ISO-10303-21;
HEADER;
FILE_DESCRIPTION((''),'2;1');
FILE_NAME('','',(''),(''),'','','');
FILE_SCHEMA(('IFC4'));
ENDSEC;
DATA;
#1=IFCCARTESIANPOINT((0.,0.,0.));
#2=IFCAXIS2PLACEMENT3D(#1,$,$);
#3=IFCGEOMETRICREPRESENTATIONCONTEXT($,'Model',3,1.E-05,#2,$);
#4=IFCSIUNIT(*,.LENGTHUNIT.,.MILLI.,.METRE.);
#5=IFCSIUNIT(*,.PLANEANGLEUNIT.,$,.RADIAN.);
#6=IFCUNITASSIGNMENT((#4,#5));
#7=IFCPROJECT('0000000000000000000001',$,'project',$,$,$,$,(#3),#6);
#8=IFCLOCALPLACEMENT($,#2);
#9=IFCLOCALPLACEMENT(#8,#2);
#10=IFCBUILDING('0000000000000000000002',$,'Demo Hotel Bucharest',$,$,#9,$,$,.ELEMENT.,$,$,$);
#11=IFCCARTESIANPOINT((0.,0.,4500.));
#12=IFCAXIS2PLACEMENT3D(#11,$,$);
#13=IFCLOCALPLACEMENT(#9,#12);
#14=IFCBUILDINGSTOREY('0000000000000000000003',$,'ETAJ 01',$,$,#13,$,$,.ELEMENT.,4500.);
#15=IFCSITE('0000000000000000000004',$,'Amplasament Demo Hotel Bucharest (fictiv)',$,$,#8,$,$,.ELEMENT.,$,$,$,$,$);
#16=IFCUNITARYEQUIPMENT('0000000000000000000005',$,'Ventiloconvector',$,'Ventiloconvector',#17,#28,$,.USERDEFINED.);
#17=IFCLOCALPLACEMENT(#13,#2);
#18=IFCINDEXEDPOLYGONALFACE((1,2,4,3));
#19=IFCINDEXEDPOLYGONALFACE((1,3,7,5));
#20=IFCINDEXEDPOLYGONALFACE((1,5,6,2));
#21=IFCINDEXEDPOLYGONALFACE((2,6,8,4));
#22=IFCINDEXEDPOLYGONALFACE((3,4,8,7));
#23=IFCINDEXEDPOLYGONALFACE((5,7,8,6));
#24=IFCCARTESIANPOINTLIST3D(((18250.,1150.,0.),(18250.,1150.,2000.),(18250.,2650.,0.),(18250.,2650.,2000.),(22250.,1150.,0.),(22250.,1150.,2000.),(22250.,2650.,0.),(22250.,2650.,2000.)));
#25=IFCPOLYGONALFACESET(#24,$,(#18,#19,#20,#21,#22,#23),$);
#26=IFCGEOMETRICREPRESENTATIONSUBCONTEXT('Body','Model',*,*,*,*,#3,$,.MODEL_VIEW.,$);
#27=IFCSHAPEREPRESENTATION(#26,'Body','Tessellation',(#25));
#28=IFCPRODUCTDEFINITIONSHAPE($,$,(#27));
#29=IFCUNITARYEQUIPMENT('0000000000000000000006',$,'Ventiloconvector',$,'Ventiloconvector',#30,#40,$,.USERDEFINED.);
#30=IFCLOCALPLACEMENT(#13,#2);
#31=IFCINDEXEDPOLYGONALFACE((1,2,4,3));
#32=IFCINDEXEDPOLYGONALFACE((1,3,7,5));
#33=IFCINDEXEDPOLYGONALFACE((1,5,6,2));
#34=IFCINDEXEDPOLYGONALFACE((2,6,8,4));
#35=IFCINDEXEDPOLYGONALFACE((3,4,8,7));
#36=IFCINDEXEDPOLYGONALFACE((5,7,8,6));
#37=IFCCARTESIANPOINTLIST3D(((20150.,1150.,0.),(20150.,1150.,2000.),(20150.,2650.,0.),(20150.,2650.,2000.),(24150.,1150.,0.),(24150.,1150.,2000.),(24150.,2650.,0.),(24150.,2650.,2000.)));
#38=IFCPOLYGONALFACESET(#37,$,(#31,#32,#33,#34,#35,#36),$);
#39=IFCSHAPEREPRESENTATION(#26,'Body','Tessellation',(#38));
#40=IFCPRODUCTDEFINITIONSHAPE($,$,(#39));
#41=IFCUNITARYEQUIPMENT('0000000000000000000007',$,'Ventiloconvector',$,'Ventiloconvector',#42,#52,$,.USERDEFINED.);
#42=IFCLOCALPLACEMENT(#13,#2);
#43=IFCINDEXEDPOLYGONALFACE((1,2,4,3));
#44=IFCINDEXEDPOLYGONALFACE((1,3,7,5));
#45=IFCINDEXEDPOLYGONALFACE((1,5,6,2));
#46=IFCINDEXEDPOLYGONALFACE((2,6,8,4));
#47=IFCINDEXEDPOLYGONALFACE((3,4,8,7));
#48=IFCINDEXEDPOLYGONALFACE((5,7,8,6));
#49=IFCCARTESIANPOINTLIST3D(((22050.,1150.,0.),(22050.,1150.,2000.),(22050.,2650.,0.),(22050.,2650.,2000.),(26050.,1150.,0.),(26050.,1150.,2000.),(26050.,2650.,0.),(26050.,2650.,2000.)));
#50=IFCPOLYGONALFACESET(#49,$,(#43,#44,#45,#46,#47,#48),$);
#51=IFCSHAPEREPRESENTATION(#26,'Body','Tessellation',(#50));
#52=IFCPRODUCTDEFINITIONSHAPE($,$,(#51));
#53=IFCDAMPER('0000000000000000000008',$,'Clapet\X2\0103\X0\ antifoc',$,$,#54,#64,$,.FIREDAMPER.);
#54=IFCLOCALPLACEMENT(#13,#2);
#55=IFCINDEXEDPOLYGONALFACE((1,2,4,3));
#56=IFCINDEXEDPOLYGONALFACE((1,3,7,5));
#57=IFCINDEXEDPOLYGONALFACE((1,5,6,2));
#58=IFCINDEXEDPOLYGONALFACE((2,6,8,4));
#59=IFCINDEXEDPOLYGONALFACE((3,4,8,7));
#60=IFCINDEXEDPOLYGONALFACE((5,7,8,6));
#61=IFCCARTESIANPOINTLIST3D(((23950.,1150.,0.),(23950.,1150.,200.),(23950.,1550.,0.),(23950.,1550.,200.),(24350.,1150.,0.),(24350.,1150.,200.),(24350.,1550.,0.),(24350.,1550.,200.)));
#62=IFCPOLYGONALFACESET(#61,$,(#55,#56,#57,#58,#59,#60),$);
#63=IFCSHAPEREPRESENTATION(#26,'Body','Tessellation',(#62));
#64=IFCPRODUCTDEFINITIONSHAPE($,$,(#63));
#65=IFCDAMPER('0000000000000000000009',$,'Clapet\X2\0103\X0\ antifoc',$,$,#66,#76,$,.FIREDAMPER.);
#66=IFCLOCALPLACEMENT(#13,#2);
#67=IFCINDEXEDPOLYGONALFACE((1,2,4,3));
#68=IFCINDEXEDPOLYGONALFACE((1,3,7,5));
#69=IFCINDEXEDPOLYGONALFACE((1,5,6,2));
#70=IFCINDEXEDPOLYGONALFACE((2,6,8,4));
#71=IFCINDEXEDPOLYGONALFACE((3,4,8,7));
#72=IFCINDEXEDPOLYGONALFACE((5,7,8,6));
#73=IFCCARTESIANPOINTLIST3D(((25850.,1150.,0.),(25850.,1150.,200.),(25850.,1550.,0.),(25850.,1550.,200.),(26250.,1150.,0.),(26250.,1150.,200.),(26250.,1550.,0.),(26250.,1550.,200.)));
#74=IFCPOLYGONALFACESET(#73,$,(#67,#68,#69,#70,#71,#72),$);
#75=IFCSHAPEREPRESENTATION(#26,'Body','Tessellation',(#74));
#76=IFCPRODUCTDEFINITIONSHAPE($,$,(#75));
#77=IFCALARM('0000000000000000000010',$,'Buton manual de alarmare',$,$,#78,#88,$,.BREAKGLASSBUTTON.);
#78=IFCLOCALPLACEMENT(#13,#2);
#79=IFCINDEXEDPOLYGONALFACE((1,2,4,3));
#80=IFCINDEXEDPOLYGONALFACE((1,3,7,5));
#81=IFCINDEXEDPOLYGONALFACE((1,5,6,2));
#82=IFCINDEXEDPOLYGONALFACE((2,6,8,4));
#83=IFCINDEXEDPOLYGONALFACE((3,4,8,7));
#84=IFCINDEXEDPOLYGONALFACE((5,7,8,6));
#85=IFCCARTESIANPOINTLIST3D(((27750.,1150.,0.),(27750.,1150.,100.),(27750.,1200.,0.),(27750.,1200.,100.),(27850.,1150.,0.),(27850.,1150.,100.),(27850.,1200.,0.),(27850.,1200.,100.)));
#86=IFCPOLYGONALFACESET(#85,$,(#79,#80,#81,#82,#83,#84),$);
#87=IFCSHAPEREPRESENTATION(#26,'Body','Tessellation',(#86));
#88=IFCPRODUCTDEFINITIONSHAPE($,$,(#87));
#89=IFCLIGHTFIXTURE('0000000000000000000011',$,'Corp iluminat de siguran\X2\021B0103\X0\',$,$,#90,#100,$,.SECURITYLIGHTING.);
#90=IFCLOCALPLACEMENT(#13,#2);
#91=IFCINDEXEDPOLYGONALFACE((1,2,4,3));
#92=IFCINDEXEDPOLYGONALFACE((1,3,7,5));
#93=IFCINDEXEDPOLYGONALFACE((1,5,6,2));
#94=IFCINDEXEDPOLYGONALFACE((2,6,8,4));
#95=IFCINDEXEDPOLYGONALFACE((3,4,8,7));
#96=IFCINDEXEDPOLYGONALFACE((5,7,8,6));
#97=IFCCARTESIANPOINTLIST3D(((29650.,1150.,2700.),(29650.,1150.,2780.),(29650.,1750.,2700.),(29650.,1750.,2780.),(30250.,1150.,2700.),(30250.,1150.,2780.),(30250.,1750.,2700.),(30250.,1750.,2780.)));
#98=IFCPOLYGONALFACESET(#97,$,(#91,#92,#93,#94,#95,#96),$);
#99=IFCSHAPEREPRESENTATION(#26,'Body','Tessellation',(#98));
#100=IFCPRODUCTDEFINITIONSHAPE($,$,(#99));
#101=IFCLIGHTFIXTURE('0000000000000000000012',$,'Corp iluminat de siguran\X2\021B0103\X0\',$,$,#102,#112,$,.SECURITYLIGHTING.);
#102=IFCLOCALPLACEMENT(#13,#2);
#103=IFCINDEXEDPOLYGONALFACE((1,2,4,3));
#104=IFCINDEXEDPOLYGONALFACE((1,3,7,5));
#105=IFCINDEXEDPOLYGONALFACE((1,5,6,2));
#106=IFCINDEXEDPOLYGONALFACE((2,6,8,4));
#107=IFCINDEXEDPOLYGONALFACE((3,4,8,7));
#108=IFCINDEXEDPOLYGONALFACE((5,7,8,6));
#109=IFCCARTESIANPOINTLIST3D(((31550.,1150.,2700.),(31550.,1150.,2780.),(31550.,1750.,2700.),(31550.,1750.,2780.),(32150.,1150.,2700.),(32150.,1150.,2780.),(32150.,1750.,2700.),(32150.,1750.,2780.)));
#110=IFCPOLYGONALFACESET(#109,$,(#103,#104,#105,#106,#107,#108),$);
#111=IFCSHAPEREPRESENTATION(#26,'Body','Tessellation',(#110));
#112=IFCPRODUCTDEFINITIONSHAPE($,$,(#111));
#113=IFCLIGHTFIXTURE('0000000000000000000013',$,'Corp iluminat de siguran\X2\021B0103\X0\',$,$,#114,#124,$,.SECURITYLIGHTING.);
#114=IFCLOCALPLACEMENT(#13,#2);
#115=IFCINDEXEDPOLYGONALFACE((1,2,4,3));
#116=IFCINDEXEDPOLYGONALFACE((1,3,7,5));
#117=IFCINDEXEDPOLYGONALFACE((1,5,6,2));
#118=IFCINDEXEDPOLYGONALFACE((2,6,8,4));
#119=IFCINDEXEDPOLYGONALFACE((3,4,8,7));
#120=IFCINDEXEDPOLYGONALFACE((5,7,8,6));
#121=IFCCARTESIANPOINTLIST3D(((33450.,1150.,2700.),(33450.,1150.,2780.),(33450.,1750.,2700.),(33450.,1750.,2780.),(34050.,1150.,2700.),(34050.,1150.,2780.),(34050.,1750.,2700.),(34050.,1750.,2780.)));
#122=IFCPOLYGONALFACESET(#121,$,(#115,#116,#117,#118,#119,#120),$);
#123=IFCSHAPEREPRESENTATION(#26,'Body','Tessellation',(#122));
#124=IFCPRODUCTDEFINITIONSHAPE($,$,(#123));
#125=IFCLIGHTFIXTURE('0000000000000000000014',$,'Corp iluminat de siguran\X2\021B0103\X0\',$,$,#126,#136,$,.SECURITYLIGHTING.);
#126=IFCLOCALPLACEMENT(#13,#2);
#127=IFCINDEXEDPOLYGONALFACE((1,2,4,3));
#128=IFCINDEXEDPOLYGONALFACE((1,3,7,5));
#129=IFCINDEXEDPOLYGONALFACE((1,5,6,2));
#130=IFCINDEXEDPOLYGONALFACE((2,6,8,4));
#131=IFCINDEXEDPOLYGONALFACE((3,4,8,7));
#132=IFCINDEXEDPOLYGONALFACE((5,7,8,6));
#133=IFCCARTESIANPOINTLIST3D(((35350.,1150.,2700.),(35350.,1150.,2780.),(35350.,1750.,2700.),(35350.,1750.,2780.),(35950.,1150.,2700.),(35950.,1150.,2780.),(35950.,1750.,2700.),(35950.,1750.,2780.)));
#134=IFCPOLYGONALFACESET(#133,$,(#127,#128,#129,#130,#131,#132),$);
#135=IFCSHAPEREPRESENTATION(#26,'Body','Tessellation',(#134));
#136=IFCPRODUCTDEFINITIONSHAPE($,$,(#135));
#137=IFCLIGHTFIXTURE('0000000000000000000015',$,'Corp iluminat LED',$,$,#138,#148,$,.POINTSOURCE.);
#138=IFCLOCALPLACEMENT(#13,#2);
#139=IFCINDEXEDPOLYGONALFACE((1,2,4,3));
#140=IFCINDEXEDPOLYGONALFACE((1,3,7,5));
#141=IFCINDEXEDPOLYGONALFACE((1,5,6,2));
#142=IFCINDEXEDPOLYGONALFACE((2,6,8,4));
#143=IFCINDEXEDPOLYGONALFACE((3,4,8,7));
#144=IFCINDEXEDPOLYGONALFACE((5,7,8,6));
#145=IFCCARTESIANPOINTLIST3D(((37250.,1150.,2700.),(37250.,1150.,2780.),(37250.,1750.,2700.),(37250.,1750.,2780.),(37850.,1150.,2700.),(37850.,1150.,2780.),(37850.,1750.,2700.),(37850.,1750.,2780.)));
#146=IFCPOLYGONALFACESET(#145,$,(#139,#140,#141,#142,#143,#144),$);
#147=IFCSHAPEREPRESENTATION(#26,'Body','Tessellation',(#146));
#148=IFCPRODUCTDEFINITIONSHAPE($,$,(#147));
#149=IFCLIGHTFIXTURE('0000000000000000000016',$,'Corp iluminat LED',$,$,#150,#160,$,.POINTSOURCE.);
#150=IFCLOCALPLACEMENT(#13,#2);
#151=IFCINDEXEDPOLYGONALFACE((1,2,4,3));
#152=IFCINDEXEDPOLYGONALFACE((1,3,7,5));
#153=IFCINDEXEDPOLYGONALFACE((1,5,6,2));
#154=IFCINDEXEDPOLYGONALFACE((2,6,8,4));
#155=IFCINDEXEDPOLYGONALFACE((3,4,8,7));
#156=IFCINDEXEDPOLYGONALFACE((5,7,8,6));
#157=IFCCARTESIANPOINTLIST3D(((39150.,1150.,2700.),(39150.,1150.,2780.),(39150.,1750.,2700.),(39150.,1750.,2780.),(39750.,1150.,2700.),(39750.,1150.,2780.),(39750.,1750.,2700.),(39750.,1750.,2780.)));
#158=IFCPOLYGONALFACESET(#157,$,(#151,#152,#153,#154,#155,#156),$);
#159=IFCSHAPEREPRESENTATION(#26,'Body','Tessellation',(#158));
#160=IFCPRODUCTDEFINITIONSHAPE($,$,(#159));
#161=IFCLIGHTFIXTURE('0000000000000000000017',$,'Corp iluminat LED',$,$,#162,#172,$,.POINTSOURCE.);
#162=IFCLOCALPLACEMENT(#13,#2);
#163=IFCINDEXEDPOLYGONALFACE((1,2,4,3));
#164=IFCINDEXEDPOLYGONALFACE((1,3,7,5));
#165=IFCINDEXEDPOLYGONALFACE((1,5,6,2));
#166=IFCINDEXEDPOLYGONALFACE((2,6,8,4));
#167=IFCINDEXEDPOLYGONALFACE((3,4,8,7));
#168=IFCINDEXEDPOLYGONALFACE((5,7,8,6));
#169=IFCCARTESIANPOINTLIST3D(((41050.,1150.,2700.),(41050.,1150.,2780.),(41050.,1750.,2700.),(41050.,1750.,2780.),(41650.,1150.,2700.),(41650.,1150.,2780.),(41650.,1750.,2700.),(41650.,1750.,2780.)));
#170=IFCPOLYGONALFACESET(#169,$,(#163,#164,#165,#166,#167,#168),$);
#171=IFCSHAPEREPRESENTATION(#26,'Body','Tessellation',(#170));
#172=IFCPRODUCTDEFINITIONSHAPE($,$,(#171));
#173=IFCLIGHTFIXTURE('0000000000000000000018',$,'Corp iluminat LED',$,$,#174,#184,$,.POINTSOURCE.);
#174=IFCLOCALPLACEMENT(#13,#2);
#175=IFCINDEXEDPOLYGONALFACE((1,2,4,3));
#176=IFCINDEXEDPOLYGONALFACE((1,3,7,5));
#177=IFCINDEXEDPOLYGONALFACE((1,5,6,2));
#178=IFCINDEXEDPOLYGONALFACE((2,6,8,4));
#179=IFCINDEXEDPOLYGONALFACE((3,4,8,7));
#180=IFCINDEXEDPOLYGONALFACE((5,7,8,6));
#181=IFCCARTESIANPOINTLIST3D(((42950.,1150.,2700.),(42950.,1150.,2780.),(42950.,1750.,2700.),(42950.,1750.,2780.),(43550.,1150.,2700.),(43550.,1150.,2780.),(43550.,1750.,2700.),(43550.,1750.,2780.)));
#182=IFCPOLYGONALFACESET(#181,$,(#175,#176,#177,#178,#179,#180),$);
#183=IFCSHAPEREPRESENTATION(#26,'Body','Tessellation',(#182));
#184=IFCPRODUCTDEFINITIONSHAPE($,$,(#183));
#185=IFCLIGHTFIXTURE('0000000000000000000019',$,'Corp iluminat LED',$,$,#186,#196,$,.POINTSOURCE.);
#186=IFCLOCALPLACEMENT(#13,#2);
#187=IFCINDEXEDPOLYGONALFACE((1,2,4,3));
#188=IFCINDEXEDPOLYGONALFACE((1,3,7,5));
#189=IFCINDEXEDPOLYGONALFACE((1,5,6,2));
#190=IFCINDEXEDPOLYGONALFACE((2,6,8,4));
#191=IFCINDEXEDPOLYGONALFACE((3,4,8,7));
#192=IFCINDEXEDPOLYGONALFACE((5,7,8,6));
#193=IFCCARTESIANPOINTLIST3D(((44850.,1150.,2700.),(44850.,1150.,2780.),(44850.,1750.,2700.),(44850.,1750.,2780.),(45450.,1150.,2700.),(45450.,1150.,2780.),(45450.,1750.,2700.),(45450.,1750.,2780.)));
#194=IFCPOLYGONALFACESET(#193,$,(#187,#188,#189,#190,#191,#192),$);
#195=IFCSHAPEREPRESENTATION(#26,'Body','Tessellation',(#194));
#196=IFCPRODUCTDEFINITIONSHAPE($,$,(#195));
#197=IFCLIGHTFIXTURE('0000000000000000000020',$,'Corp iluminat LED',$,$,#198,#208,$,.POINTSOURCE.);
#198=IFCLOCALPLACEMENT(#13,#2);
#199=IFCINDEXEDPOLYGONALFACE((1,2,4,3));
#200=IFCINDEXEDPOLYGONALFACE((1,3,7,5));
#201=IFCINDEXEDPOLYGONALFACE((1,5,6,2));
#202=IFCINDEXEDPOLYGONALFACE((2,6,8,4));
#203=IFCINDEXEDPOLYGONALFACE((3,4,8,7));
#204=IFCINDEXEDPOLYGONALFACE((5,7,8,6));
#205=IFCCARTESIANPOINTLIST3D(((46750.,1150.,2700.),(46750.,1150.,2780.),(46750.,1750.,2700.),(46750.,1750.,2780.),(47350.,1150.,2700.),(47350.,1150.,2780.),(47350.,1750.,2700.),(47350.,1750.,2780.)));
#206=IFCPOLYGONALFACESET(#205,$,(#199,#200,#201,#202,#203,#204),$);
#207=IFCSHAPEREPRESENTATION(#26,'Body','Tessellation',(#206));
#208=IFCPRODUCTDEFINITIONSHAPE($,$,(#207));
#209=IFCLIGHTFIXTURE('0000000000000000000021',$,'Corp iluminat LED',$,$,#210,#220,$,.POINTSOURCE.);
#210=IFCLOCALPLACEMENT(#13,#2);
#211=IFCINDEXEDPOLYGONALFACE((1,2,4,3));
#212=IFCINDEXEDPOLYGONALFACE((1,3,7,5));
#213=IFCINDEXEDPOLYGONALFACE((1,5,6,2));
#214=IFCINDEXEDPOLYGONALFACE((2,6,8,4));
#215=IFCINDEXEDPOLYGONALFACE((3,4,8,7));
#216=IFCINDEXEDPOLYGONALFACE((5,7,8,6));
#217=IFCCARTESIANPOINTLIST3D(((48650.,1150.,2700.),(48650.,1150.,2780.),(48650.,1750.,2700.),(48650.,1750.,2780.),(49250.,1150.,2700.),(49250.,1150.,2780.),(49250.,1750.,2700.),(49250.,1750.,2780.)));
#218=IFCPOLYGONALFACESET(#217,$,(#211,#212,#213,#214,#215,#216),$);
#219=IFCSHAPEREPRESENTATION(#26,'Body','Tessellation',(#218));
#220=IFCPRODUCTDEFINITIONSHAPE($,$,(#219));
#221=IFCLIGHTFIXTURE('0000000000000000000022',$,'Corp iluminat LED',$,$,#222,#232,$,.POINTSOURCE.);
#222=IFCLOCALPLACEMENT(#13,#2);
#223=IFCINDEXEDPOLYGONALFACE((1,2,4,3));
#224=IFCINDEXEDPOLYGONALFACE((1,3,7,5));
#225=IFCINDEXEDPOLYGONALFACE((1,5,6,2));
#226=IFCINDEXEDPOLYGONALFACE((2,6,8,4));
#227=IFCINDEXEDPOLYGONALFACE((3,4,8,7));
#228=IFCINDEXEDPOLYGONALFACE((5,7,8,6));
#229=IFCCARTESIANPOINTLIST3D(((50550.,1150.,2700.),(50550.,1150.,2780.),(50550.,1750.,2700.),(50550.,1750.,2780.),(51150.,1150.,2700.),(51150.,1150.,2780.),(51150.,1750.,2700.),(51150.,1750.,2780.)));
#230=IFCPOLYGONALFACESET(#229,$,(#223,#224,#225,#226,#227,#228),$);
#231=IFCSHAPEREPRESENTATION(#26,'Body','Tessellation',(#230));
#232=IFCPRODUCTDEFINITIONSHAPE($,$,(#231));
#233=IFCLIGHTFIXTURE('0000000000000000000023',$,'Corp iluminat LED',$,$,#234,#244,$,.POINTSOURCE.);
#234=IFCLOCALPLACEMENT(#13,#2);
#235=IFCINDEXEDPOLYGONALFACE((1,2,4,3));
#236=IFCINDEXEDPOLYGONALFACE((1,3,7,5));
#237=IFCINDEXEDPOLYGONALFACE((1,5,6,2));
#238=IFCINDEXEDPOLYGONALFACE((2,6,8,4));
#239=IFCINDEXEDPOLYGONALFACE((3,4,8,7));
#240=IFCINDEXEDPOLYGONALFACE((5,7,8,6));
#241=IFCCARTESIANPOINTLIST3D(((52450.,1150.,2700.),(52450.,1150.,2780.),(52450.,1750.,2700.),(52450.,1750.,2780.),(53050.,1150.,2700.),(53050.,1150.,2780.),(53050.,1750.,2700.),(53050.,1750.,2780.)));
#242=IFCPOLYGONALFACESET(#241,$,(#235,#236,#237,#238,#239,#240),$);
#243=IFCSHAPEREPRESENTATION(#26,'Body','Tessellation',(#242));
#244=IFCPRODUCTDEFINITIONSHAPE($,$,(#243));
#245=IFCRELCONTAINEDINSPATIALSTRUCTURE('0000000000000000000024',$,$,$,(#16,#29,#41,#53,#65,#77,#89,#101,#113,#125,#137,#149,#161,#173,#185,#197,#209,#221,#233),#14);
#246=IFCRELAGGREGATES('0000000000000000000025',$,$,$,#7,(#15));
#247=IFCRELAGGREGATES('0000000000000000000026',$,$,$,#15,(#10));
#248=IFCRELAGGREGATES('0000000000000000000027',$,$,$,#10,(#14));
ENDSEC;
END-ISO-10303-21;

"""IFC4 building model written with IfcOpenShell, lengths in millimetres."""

from ifc_helpers import new_model, si_unit, frame, frame_2d, origin, place, context, subcontext, project, spatial, rectangle, extrude, element, save


model = new_model("IFC4")

# Units and contexts
model_context = context("Model", 3, precision=1e-05, world=origin())
body_context = subcontext(model_context, "Body", "Model", "MODEL_VIEW")
ifc_project = project(units=[si_unit("LENGTHUNIT", "METRE", prefix="MILLI"), si_unit("PLANEANGLEUNIT", "RADIAN")], contexts=[model_context])

# Site, building, storey
site_placement = place(None, origin())
site = spatial("IfcSite", under=ifc_project, at=site_placement, Name="Amplasament Demo Hotel Bucharest (fictiv)", CompositionType="ELEMENT")
building_placement = place(site_placement, origin())
building = spatial("IfcBuilding", under=site, at=building_placement, Name="Demo Hotel Bucharest", CompositionType="ELEMENT")
storey_placement = place(building_placement, frame((0.0, 0.0, 4500.0)))
storey = spatial("IfcBuildingStorey", under=building, at=storey_placement, Name="ETAJ 01", CompositionType="ELEMENT", Elevation=4500.0)

# Unitary equipment
for number, where, name in (
    (1, (18250.0, 1150.0, 0.0), "Ventiloconvector"),
    (2, (20150.0, 1150.0, 0.0), "Ventiloconvector"),
    (3, (22050.0, 1150.0, 0.0), "Ventiloconvector"),
):
    element("IfcUnitaryEquipment", number, at=place(storey_placement, frame(where)), inside=storey, Name=name, ObjectType="Ventiloconvector", PredefinedType="USERDEFINED", context=body_context, shape_type="SweptSolid", body=[
        extrude(rectangle(XDim=4000.0, YDim=1500.0, at=frame_2d((2000.0, 750.0))), origin(), (0.0, 0.0, 1.0), 2000.0),
    ])

# Dampers
for number, where, name in (
    (4, (23950.0, 1150.0, 0.0), "Clapetă antifoc"),
    (5, (25850.0, 1150.0, 0.0), "Clapetă antifoc"),
):
    element("IfcDamper", number, at=place(storey_placement, frame(where)), inside=storey, Name=name, PredefinedType="FIREDAMPER", context=body_context, shape_type="SweptSolid", body=[
        extrude(rectangle(XDim=400.0, YDim=400.0, at=frame_2d((200.0, 200.0))), origin(), (0.0, 0.0, 1.0), 200.0),
    ])

# Alarm
alarm_placement = place(storey_placement, frame((27750.0, 1150.0, 0.0)))
element("IfcAlarm", 6, at=alarm_placement, inside=storey, Name="Buton manual de alarmare", PredefinedType="BREAKGLASSBUTTON", context=body_context, shape_type="SweptSolid", body=[
    extrude(rectangle(XDim=100.0, YDim=50.0, at=frame_2d((50.0, 25.0))), origin(), (0.0, 0.0, 1.0), 100.0),
])

# Light fixtures
for number, where, name in (
    (7, (29650.0, 1150.0, 2700.0), "Corp iluminat de siguranță"),
    (8, (31550.0, 1150.0, 2700.0), "Corp iluminat de siguranță"),
    (9, (33450.0, 1150.0, 2700.0), "Corp iluminat de siguranță"),
    (10, (35350.0, 1150.0, 2700.0), "Corp iluminat de siguranță"),
):
    element("IfcLightFixture", number, at=place(storey_placement, frame(where)), inside=storey, Name=name, PredefinedType="SECURITYLIGHTING", context=body_context, shape_type="SweptSolid", body=[
        extrude(rectangle(XDim=600.0, YDim=600.0, at=frame_2d((300.0, 300.0))), origin(), (0.0, 0.0, 1.0), 80.0),
    ])
for number, where, name in (
    (11, (37250.0, 1150.0, 2700.0), "Corp iluminat LED"),
    (12, (39150.0, 1150.0, 2700.0), "Corp iluminat LED"),
    (13, (41050.0, 1150.0, 2700.0), "Corp iluminat LED"),
    (14, (42950.0, 1150.0, 2700.0), "Corp iluminat LED"),
    (15, (44850.0, 1150.0, 2700.0), "Corp iluminat LED"),
    (16, (46750.0, 1150.0, 2700.0), "Corp iluminat LED"),
    (17, (48650.0, 1150.0, 2700.0), "Corp iluminat LED"),
    (18, (50550.0, 1150.0, 2700.0), "Corp iluminat LED"),
    (19, (52450.0, 1150.0, 2700.0), "Corp iluminat LED"),
):
    element("IfcLightFixture", number, at=place(storey_placement, frame(where)), inside=storey, Name=name, PredefinedType="POINTSOURCE", context=body_context, shape_type="SweptSolid", body=[
        extrude(rectangle(XDim=600.0, YDim=600.0, at=frame_2d((300.0, 300.0))), origin(), (0.0, 0.0, 1.0), 80.0),
    ])

save(model, "model.ifc")
